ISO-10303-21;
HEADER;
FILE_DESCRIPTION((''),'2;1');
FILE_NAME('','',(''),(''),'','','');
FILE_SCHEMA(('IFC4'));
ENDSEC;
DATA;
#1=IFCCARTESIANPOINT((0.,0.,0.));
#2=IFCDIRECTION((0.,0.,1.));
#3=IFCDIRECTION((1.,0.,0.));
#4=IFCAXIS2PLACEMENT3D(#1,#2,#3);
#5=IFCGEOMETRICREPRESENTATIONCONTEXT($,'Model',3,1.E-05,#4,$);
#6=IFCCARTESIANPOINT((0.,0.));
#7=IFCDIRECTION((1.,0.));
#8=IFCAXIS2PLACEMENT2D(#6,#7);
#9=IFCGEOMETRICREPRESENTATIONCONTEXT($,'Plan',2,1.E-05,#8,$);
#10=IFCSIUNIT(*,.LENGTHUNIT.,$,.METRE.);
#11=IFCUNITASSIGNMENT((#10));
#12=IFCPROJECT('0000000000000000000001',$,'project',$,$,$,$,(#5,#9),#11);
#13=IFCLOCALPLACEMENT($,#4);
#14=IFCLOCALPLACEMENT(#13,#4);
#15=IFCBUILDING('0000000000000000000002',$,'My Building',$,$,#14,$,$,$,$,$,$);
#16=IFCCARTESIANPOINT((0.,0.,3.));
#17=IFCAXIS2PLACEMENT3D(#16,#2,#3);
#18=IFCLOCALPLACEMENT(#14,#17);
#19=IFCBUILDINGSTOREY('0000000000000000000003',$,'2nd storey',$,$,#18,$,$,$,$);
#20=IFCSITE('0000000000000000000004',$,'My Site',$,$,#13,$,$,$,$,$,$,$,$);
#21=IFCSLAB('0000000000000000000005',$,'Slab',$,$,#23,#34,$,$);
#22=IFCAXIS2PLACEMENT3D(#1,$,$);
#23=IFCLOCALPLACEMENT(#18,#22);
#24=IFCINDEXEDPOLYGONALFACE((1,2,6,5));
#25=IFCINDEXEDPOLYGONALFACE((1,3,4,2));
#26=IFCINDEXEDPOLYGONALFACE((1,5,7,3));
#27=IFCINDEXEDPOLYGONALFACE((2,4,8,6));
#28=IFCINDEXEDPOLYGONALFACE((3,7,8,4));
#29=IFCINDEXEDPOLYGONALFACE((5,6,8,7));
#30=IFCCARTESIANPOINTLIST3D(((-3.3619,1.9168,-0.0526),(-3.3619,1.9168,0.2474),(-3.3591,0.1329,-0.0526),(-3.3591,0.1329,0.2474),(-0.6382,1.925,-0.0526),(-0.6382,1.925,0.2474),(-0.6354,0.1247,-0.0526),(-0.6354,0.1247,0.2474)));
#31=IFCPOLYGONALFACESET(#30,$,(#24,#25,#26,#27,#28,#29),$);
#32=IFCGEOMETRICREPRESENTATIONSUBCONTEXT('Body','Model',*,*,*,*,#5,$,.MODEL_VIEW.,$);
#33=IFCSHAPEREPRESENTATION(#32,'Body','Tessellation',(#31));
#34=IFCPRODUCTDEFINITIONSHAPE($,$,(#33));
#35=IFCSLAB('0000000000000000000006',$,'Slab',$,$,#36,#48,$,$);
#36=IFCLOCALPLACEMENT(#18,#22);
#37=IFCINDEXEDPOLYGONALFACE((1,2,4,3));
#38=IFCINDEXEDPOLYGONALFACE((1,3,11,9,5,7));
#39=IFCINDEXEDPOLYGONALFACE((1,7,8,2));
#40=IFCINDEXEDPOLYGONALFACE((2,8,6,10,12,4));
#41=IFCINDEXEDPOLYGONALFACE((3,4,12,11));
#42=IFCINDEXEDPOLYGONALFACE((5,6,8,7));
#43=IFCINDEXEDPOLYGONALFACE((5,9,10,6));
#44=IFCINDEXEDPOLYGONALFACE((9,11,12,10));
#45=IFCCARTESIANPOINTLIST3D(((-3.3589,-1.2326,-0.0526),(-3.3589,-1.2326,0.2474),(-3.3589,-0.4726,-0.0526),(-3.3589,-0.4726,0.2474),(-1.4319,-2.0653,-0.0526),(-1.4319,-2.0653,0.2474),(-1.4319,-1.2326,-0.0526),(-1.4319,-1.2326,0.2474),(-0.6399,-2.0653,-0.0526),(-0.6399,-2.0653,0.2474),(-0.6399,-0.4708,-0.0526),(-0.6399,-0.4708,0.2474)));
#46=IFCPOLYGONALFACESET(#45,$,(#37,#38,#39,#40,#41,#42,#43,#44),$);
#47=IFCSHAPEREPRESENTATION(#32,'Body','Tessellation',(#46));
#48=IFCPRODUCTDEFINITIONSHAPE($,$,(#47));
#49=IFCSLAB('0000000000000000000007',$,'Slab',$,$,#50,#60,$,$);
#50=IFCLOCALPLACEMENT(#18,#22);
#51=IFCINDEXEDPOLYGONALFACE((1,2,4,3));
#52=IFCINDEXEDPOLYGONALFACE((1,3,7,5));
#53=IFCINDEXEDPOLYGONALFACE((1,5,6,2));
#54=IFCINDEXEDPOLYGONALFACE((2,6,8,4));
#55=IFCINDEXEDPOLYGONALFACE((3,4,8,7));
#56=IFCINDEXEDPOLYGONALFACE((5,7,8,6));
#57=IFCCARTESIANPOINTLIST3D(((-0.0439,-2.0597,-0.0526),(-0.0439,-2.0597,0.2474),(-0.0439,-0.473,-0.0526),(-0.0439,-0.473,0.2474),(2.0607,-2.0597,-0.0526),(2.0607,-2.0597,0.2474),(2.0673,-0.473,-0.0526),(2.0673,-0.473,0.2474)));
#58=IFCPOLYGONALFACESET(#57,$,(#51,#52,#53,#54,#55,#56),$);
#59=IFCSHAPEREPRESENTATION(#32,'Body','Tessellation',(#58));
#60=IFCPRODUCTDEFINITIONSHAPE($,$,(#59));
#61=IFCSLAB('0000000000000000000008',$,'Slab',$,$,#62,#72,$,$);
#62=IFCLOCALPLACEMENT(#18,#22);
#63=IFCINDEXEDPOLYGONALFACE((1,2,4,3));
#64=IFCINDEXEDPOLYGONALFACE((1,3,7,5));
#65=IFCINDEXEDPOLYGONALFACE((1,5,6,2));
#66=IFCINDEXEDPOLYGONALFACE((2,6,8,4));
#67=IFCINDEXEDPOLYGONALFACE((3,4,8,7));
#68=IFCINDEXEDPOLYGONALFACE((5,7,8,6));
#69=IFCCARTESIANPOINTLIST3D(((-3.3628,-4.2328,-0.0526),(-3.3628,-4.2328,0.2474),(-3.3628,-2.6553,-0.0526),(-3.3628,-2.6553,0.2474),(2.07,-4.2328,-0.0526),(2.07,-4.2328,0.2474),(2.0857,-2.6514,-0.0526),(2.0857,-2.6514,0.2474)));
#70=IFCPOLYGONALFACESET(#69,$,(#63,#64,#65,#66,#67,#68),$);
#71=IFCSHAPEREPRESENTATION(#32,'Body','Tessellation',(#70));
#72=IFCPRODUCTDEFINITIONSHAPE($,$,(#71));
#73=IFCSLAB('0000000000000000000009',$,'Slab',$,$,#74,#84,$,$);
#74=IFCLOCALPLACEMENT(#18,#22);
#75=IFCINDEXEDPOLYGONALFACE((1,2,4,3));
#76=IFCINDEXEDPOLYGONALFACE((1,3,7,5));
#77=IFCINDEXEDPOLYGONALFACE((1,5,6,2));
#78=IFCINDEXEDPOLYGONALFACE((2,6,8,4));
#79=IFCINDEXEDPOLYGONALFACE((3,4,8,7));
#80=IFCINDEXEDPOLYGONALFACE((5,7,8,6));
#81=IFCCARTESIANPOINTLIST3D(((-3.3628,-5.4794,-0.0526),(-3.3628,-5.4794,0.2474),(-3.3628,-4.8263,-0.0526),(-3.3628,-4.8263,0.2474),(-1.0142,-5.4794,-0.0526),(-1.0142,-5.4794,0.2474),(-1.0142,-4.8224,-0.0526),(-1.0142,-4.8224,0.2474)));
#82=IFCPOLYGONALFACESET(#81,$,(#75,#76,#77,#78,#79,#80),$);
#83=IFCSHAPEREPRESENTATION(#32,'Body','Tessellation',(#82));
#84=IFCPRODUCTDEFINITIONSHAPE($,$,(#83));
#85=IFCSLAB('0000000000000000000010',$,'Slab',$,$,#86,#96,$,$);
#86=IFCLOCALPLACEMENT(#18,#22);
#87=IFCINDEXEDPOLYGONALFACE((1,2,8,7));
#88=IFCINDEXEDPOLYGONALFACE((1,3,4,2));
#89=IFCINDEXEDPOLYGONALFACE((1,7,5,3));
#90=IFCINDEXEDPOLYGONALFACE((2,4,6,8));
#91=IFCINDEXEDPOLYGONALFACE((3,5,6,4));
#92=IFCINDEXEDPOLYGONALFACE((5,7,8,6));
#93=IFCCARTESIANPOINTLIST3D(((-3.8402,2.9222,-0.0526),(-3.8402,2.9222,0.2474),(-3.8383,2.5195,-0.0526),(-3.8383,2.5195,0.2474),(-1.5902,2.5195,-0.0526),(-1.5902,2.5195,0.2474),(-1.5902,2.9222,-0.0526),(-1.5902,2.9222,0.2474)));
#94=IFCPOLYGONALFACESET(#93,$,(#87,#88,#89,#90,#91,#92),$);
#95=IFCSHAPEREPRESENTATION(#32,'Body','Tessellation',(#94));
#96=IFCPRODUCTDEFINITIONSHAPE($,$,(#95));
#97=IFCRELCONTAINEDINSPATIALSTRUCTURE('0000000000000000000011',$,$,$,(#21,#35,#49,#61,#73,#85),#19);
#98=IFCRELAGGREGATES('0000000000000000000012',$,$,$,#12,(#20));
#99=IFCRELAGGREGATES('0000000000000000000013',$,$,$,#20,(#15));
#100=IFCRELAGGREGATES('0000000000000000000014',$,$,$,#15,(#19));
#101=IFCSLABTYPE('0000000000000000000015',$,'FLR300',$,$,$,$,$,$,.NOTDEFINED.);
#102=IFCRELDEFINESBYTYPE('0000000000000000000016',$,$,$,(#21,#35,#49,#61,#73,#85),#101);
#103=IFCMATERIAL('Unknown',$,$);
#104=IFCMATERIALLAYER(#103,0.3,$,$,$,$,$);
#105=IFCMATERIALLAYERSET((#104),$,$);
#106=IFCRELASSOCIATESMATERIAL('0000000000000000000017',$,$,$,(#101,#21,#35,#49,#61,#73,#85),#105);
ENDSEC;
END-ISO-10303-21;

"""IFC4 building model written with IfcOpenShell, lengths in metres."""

from ifc_helpers import new_model, si_unit, frame, origin_with_axes, origin_2d_with_axis, place, context, subcontext, project, spatial, indexed_curve, outline, extrude, material, layer, layer_set, layer_usage, type_object, element, save


model = new_model("IFC4")

# Units and contexts
model_context = context("Model", 3, precision=1e-05, world=origin_with_axes())
plan_context = context("Plan", 2, precision=1e-05, world=origin_2d_with_axis())
body_context = subcontext(model_context, "Body", "Model", "MODEL_VIEW")
ifc_project = project(units=[si_unit("LENGTHUNIT", "METRE")], contexts=[model_context, plan_context])

# Site, building, storey
site_placement = place(None, origin_with_axes())
site = spatial("IfcSite", under=ifc_project, at=site_placement, Name="My Site")
building_placement = place(site_placement, origin_with_axes())
building = spatial("IfcBuilding", under=site, at=building_placement, Name="My Building")
storey_placement = place(building_placement, frame((0.0, 0.0, 3.0), z_axis=(0.0, 0.0, 1.0), x_axis=(1.0, 0.0, 0.0)))
storey = spatial("IfcBuildingStorey", under=building, at=storey_placement, Name="2nd storey")

# Shared definitions
ifc_material = material(Name="Unknown")

# Slabs
ifc_layer_1 = layer(ifc_material, 0.3)
ifc_layer_set_1 = layer_set([ifc_layer_1])
ifc_layer_usage_1 = layer_usage(ifc_layer_set_1, "AXIS3", "POSITIVE", -0.3)
slab_type_1 = type_object("IfcSlabType", Name="FLR300", PredefinedType="NOTDEFINED", material=ifc_layer_set_1)
slab_1_placement = place(storey_placement, frame((-3.3619, 1.9168, 0.2474), z_axis=(0.0, 0.0, 1.0), x_axis=(1.0, 0.0, 0.0)))
element("IfcSlab", 1, at=slab_1_placement, inside=storey, type_object=slab_type_1, material=ifc_layer_usage_1, Name="Slab", context=body_context, shape_type="SweptSolid", body=[
    extrude(outline(indexed_curve([(0.0, 0.0), (0.0027, -1.7839), (2.7264, -1.7921), (2.7237, 0.0082), (0.0, 0.0)])), frame((0.0, 0.0, -0.3), z_axis=(0.0, 0.0, 1.0), x_axis=(1.0, 0.0, 0.0)), (0.0, 0.0, 1.0), 0.3),
])
ifc_layer_usage_2 = layer_usage(ifc_layer_set_1, "AXIS3", "POSITIVE", -0.3)
slab_2_placement = place(storey_placement, frame((-3.3589, -0.4726, 0.2474), z_axis=(0.0, 0.0, 1.0), x_axis=(1.0, 0.0, 0.0)))
element("IfcSlab", 2, at=slab_2_placement, inside=storey, type_object=slab_type_1, material=ifc_layer_usage_2, Name="Slab", context=body_context, shape_type="SweptSolid", body=[
    extrude(outline(indexed_curve([(0.0, 0.0), (0.0, -0.76), (1.927, -0.76), (1.927, -1.5927), (2.719, -1.5927), (2.719, 0.0018), (0.0, 0.0)])), frame((0.0, 0.0, -0.3), z_axis=(0.0, 0.0, 1.0), x_axis=(1.0, 0.0, 0.0)), (0.0, 0.0, 1.0), 0.3),
])
ifc_layer_usage_3 = layer_usage(ifc_layer_set_1, "AXIS3", "POSITIVE", -0.3)
slab_3_placement = place(storey_placement, frame((2.0673, -0.473, 0.2474), z_axis=(0.0, 0.0, 1.0), x_axis=(1.0, 0.0, 0.0)))
element("IfcSlab", 3, at=slab_3_placement, inside=storey, type_object=slab_type_1, material=ifc_layer_usage_3, Name="Slab", context=body_context, shape_type="SweptSolid", body=[
    extrude(outline(indexed_curve([(0.0, 0.0), (-2.1112, 0.0), (-2.1112, -1.5867), (-0.0066, -1.5867), (0.0, 0.0)])), frame((0.0, 0.0, -0.3), z_axis=(0.0, 0.0, 1.0), x_axis=(1.0, 0.0, 0.0)), (0.0, 0.0, 1.0), 0.3),
])
ifc_layer_usage_4 = layer_usage(ifc_layer_set_1, "AXIS3", "POSITIVE", -0.3)
slab_4_placement = place(storey_placement, frame((-3.3628, -2.6553, 0.2474), z_axis=(0.0, 0.0, 1.0), x_axis=(1.0, 0.0, 0.0)))
element("IfcSlab", 4, at=slab_4_placement, inside=storey, type_object=slab_type_1, material=ifc_layer_usage_4, Name="Slab", context=body_context, shape_type="SweptSolid", body=[
    extrude(outline(indexed_curve([(0.0, 0.0), (0.0, -1.5775), (5.4328, -1.5775), (5.4485, 0.0039), (0.0, 0.0)])), frame((0.0, 0.0, -0.3), z_axis=(0.0, 0.0, 1.0), x_axis=(1.0, 0.0, 0.0)), (0.0, 0.0, 1.0), 0.3),
])
ifc_layer_usage_5 = layer_usage(ifc_layer_set_1, "AXIS3", "POSITIVE", -0.3)
slab_5_placement = place(storey_placement, frame((-3.3628, -4.8263, 0.2474), z_axis=(0.0, 0.0, 1.0), x_axis=(1.0, 0.0, 0.0)))
element("IfcSlab", 5, at=slab_5_placement, inside=storey, type_object=slab_type_1, material=ifc_layer_usage_5, Name="Slab", context=body_context, shape_type="SweptSolid", body=[
    extrude(outline(indexed_curve([(0.0, 0.0), (0.0, -0.653), (2.3486, -0.653), (2.3486, 0.0039), (0.0, 0.0)])), frame((0.0, 0.0, -0.3), z_axis=(0.0, 0.0, 1.0), x_axis=(1.0, 0.0, 0.0)), (0.0, 0.0, 1.0), 0.3),
])
ifc_layer_usage_6 = layer_usage(ifc_layer_set_1, "AXIS3", "POSITIVE", -0.3)
slab_6_placement = place(storey_placement, frame((-3.8402, 2.9222, 0.2474), z_axis=(0.0, 0.0, 1.0), x_axis=(1.0, 0.0, 0.0)))
element("IfcSlab", 6, at=slab_6_placement, inside=storey, type_object=slab_type_1, material=ifc_layer_usage_6, Name="Slab", context=body_context, shape_type="SweptSolid", body=[
    extrude(outline(indexed_curve([(0.0, 0.0), (2.25, 0.0), (2.25, -0.4027), (0.0019, -0.4027), (0.0, 0.0)])), frame((0.0, 0.0, -0.3), z_axis=(0.0, 0.0, 1.0), x_axis=(1.0, 0.0, 0.0)), (0.0, 0.0, 1.0), 0.3),
])

save(model, "model.ifc")
